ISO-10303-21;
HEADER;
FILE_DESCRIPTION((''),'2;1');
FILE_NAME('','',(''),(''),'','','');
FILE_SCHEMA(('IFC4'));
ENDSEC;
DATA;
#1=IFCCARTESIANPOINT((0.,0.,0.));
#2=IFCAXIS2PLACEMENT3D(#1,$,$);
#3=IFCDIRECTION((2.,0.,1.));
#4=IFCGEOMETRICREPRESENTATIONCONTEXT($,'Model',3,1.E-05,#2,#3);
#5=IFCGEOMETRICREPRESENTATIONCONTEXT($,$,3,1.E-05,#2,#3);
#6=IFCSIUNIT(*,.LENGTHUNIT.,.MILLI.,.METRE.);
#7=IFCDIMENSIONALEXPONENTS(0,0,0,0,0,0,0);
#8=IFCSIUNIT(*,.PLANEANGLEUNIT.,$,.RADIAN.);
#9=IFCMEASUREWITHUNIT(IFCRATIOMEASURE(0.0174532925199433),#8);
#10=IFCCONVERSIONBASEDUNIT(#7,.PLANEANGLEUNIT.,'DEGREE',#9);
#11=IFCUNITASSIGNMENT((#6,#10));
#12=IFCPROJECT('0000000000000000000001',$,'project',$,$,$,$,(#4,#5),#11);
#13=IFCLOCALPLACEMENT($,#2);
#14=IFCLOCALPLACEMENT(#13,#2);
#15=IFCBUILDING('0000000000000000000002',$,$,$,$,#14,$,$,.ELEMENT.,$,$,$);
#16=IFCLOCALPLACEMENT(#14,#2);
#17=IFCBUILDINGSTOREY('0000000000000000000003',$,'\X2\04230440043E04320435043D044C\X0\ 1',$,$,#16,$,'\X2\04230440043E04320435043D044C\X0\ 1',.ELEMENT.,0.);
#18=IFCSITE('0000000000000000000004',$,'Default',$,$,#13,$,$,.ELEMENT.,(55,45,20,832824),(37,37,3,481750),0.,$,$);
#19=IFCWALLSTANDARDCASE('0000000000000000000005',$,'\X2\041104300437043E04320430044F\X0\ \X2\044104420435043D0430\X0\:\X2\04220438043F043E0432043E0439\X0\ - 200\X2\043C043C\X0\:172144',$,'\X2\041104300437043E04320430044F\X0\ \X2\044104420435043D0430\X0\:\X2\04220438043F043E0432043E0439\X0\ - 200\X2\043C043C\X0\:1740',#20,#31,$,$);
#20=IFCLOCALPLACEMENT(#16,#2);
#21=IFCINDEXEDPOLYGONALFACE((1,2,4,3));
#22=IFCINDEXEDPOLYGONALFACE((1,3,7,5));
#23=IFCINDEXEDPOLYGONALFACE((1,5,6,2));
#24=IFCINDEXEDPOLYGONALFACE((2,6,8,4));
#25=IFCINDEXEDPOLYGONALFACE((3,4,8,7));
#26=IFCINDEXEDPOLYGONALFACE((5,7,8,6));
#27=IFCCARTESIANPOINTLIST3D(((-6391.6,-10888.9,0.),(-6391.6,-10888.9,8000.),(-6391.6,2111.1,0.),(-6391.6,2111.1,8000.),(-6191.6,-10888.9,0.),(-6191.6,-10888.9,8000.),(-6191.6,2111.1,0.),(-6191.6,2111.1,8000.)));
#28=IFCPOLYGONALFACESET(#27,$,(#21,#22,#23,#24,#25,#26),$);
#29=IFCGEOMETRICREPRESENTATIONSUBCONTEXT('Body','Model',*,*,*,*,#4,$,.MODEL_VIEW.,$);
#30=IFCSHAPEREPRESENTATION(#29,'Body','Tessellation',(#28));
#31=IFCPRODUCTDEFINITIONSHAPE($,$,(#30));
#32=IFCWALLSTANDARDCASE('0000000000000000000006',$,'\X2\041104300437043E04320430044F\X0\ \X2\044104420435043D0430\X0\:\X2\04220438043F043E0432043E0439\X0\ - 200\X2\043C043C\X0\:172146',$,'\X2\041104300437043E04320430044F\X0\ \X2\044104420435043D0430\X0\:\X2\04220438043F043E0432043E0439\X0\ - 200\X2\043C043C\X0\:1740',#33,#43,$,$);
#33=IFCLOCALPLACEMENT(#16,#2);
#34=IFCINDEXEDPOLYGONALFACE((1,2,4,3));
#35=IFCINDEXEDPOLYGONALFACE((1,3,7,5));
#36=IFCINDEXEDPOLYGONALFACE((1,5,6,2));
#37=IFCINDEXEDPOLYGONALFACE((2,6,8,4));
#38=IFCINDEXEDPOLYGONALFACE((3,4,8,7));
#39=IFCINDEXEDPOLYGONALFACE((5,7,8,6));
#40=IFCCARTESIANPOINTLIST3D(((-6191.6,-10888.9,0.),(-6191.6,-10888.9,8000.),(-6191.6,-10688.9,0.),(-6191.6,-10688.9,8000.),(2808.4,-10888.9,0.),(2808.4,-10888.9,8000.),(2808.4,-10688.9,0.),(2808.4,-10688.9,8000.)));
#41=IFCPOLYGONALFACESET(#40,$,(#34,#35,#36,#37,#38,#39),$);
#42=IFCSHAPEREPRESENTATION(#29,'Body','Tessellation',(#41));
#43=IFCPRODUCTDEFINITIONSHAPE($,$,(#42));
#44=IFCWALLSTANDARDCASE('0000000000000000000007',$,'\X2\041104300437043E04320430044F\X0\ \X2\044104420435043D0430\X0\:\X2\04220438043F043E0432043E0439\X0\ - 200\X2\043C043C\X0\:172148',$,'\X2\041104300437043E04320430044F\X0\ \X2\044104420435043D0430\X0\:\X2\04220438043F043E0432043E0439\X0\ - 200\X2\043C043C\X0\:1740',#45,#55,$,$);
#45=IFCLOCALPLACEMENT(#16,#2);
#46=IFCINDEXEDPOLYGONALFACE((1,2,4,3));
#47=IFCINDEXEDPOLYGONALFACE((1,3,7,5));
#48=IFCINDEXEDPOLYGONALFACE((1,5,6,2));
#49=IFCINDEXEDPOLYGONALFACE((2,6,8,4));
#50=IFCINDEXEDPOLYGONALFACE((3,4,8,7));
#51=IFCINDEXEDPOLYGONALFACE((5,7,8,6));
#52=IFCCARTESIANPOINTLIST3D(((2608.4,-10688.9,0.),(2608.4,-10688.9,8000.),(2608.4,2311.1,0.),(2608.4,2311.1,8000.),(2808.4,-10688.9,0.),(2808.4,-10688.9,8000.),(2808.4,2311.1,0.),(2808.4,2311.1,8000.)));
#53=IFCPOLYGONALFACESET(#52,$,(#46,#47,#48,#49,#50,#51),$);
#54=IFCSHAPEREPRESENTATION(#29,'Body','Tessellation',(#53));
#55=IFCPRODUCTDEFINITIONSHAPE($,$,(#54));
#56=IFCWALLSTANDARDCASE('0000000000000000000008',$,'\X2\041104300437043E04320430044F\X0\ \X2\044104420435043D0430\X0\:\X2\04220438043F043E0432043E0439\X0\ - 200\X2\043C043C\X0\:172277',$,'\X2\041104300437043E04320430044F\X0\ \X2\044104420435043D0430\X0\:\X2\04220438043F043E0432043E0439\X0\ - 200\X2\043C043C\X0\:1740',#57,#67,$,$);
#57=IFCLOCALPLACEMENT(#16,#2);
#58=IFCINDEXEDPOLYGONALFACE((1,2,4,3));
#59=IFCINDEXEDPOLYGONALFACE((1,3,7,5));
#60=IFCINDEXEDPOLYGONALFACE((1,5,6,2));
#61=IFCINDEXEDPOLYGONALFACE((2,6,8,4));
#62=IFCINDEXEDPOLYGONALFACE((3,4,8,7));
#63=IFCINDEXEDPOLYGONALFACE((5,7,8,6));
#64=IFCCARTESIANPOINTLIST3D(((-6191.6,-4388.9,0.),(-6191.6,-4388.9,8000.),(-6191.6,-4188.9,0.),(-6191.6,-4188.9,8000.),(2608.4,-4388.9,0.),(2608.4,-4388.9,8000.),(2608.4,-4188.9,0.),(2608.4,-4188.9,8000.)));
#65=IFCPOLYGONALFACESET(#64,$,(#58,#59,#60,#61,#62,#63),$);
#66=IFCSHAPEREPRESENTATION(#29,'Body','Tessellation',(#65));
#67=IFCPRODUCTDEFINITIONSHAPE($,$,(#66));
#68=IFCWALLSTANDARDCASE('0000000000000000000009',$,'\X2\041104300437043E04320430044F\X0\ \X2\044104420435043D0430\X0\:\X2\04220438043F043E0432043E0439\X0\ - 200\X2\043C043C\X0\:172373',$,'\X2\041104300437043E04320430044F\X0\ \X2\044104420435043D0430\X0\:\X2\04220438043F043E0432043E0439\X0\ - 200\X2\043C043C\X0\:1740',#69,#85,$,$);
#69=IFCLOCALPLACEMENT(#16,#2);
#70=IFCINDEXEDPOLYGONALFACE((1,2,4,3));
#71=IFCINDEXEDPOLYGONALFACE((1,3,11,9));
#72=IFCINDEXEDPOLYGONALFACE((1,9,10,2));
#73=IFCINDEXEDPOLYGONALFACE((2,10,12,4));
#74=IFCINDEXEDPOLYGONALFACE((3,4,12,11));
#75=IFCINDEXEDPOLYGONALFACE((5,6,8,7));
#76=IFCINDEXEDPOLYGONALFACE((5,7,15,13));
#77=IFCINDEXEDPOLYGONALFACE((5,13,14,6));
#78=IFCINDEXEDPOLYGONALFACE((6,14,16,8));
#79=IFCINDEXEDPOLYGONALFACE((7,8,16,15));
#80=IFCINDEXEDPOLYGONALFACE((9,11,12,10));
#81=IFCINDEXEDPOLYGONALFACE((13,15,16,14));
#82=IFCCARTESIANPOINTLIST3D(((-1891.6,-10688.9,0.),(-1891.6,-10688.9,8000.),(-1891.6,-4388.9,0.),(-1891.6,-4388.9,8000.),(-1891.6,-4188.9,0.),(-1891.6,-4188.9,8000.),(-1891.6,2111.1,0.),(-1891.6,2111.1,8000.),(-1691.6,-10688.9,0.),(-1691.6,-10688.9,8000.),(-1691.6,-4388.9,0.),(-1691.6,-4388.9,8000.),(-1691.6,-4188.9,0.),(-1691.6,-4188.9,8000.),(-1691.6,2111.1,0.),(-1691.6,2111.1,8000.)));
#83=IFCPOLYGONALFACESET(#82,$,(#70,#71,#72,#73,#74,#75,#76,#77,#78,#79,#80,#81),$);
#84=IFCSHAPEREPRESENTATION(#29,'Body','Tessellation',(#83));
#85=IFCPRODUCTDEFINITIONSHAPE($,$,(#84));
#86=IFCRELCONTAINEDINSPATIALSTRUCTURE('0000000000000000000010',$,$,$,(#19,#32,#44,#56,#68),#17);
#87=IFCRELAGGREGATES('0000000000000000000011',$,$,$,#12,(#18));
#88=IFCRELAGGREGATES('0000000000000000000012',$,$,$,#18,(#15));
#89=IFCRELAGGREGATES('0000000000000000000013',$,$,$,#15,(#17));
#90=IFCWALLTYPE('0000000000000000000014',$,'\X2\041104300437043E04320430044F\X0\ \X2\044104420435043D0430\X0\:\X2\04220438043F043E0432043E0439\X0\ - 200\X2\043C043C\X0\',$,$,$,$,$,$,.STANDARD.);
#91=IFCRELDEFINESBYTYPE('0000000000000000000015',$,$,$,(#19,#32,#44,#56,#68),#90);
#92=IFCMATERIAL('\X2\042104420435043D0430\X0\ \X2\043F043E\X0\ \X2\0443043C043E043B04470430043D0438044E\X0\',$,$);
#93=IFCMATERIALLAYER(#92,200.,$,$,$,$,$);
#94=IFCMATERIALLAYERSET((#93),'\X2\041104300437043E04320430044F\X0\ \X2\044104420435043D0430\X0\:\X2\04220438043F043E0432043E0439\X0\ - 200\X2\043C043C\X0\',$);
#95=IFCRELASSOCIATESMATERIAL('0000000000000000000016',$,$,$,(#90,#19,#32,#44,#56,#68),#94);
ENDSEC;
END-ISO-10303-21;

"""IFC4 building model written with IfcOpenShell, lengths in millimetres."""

from ifc_helpers import new_model, entity, si_unit, converted_unit, direction, frame, frame_2d, origin, origin_2d_with_axis, place, context, subcontext, project, spatial, rectangle, extrude, material, layer, layer_set, layer_usage, type_object, element, save


model = new_model("IFC4")

# Units and contexts
model_context = context("Model", 3, precision=1e-05, world=origin(), true_north=direction((2.0, 0.0, 1.0)))
context_of_model = context(None, 3, precision=1e-05, world=origin(), true_north=direction((2.0, 0.0, 1.0)))
body_context = subcontext(model_context, "Body", "Model", "MODEL_VIEW")
ifc_project = project(units=[si_unit("LENGTHUNIT", "METRE", prefix="MILLI"), converted_unit("PLANEANGLEUNIT", "DEGREE", entity("IfcRatioMeasure", 0.0174532925199433), si_unit("PLANEANGLEUNIT", "RADIAN"), dimensions=[0, 0, 0, 0, 0, 0, 0])], contexts=[model_context, context_of_model])

# Site, building, storey
site_placement = place(None, origin())
site = spatial("IfcSite", under=ifc_project, at=site_placement, Name="Default", CompositionType="ELEMENT", RefLatitude=(55, 45, 20, 832824), RefLongitude=(37, 37, 3, 481750), RefElevation=0.0)
building_placement = place(site_placement, origin())
building = spatial("IfcBuilding", under=site, at=building_placement, CompositionType="ELEMENT")
storey_placement = place(building_placement, origin())
storey = spatial("IfcBuildingStorey", under=building, at=storey_placement, Name="Уровень 1", LongName="Уровень 1", CompositionType="ELEMENT", Elevation=0.0)

# Walls
ifc_material = material(Name="Стена по умолчанию")
ifc_layer = layer(ifc_material, 200.0)
ifc_layer_set = layer_set([ifc_layer], Name="Базовая стена:Типовой - 200мм")
ifc_layer_usage_1 = layer_usage(ifc_layer_set, "AXIS2", "NEGATIVE", 100.0)
wall_type = type_object("IfcWallType", Name="Базовая стена:Типовой - 200мм", PredefinedType="STANDARD", material=ifc_layer_set)
wall_1_placement = place(storey_placement, frame((-6291.6, -10888.9, 0.0), z_axis=(0.0, 0.0, 1.0), x_axis=(0.0, 1.0, 0.0)))
element("IfcWallStandardCase", 1, at=wall_1_placement, inside=storey, type_object=wall_type, material=ifc_layer_usage_1, Name="Базовая стена:Типовой - 200мм:172144", ObjectType="Базовая стена:Типовой - 200мм:1740", context=body_context, shape_type="SweptSolid", body=[
    extrude(rectangle(XDim=13000.0, YDim=200.0, at=frame_2d((6500.0, 0.0), x_axis=(-1.0, 0.0))), origin(), (0.0, 0.0, 1.0), 8000.0),
])
ifc_layer_usage_2 = layer_usage(ifc_layer_set, "AXIS2", "NEGATIVE", 100.0)
wall_2_placement = place(storey_placement, frame((2808.4, -10788.9, 0.0), z_axis=(0.0, 0.0, 1.0), x_axis=(-1.0, 0.0, 0.0)))
element("IfcWallStandardCase", 2, at=wall_2_placement, inside=storey, type_object=wall_type, material=ifc_layer_usage_2, Name="Базовая стена:Типовой - 200мм:172146", ObjectType="Базовая стена:Типовой - 200мм:1740", context=body_context, shape_type="SweptSolid", body=[
    extrude(rectangle(XDim=9000.0, YDim=200.0, at=frame_2d((4500.0, 0.0), x_axis=(-1.0, 0.0))), origin(), (0.0, 0.0, 1.0), 8000.0),
])
ifc_layer_usage_3 = layer_usage(ifc_layer_set, "AXIS2", "NEGATIVE", 100.0)
wall_3_placement = place(storey_placement, frame((2708.4, 2311.1, 0.0), z_axis=(0.0, 0.0, 1.0), x_axis=(0.0, -1.0, 0.0)))
element("IfcWallStandardCase", 3, at=wall_3_placement, inside=storey, type_object=wall_type, material=ifc_layer_usage_3, Name="Базовая стена:Типовой - 200мм:172148", ObjectType="Базовая стена:Типовой - 200мм:1740", context=body_context, shape_type="SweptSolid", body=[
    extrude(rectangle(XDim=13000.0, YDim=200.0, at=frame_2d((6500.0, 0.0), x_axis=(-1.0, 0.0))), origin(), (0.0, 0.0, 1.0), 8000.0),
])
ifc_layer_usage_4 = layer_usage(ifc_layer_set, "AXIS2", "NEGATIVE", 100.0)
wall_4_placement = place(storey_placement, frame((-6191.6, -4288.9, 0.0)))
element("IfcWallStandardCase", 4, at=wall_4_placement, inside=storey, type_object=wall_type, material=ifc_layer_usage_4, Name="Базовая стена:Типовой - 200мм:172277", ObjectType="Базовая стена:Типовой - 200мм:1740", context=body_context, shape_type="SweptSolid", body=[
    extrude(rectangle(XDim=8800.0, YDim=200.0, at=frame_2d((4400.0, 0.0), x_axis=(-1.0, 0.0))), origin(), (0.0, 0.0, 1.0), 8000.0),
])

# Wall, opening
ifc_layer_usage_5 = layer_usage(ifc_layer_set, "AXIS2", "NEGATIVE", 100.0)
wall_5_placement = place(storey_placement, frame((-1791.6, -10688.9, 0.0), z_axis=(0.0, 0.0, 1.0), x_axis=(0.0, 1.0, 0.0)))
wall_5 = element("IfcWallStandardCase", 5, at=wall_5_placement, inside=storey, type_object=wall_type, material=ifc_layer_usage_5, Name="Базовая стена:Типовой - 200мм:172373", ObjectType="Базовая стена:Типовой - 200мм:1740", context=body_context, shape_type="SweptSolid", body=[
    extrude(rectangle(XDim=12800.0, YDim=200.0, at=frame_2d((6400.0, 0.0), x_axis=(-1.0, 0.0))), origin(), (0.0, 0.0, 1.0), 8000.0),
])
opening_placement = place(storey_placement, frame((-1791.6, -10688.9, 0.0), z_axis=(0.0, 0.0, 1.0), x_axis=(0.0, 1.0, 0.0)))
element("IfcOpeningElement", 6, at=opening_placement, cuts=wall_5, ObjectType="Opening", context=body_context, shape_type="SweptSolid", body=[
    extrude(rectangle(XDim=8000.0, YDim=200.0, at=origin_2d_with_axis()), frame((6300.0, 0.0, 4000.0), z_axis=(1.0, 0.0, 0.0), x_axis=(0.0, 0.0, -1.0)), (0.0, 0.0, 1.0), 200.0),
])

save(model, "model.ifc")
